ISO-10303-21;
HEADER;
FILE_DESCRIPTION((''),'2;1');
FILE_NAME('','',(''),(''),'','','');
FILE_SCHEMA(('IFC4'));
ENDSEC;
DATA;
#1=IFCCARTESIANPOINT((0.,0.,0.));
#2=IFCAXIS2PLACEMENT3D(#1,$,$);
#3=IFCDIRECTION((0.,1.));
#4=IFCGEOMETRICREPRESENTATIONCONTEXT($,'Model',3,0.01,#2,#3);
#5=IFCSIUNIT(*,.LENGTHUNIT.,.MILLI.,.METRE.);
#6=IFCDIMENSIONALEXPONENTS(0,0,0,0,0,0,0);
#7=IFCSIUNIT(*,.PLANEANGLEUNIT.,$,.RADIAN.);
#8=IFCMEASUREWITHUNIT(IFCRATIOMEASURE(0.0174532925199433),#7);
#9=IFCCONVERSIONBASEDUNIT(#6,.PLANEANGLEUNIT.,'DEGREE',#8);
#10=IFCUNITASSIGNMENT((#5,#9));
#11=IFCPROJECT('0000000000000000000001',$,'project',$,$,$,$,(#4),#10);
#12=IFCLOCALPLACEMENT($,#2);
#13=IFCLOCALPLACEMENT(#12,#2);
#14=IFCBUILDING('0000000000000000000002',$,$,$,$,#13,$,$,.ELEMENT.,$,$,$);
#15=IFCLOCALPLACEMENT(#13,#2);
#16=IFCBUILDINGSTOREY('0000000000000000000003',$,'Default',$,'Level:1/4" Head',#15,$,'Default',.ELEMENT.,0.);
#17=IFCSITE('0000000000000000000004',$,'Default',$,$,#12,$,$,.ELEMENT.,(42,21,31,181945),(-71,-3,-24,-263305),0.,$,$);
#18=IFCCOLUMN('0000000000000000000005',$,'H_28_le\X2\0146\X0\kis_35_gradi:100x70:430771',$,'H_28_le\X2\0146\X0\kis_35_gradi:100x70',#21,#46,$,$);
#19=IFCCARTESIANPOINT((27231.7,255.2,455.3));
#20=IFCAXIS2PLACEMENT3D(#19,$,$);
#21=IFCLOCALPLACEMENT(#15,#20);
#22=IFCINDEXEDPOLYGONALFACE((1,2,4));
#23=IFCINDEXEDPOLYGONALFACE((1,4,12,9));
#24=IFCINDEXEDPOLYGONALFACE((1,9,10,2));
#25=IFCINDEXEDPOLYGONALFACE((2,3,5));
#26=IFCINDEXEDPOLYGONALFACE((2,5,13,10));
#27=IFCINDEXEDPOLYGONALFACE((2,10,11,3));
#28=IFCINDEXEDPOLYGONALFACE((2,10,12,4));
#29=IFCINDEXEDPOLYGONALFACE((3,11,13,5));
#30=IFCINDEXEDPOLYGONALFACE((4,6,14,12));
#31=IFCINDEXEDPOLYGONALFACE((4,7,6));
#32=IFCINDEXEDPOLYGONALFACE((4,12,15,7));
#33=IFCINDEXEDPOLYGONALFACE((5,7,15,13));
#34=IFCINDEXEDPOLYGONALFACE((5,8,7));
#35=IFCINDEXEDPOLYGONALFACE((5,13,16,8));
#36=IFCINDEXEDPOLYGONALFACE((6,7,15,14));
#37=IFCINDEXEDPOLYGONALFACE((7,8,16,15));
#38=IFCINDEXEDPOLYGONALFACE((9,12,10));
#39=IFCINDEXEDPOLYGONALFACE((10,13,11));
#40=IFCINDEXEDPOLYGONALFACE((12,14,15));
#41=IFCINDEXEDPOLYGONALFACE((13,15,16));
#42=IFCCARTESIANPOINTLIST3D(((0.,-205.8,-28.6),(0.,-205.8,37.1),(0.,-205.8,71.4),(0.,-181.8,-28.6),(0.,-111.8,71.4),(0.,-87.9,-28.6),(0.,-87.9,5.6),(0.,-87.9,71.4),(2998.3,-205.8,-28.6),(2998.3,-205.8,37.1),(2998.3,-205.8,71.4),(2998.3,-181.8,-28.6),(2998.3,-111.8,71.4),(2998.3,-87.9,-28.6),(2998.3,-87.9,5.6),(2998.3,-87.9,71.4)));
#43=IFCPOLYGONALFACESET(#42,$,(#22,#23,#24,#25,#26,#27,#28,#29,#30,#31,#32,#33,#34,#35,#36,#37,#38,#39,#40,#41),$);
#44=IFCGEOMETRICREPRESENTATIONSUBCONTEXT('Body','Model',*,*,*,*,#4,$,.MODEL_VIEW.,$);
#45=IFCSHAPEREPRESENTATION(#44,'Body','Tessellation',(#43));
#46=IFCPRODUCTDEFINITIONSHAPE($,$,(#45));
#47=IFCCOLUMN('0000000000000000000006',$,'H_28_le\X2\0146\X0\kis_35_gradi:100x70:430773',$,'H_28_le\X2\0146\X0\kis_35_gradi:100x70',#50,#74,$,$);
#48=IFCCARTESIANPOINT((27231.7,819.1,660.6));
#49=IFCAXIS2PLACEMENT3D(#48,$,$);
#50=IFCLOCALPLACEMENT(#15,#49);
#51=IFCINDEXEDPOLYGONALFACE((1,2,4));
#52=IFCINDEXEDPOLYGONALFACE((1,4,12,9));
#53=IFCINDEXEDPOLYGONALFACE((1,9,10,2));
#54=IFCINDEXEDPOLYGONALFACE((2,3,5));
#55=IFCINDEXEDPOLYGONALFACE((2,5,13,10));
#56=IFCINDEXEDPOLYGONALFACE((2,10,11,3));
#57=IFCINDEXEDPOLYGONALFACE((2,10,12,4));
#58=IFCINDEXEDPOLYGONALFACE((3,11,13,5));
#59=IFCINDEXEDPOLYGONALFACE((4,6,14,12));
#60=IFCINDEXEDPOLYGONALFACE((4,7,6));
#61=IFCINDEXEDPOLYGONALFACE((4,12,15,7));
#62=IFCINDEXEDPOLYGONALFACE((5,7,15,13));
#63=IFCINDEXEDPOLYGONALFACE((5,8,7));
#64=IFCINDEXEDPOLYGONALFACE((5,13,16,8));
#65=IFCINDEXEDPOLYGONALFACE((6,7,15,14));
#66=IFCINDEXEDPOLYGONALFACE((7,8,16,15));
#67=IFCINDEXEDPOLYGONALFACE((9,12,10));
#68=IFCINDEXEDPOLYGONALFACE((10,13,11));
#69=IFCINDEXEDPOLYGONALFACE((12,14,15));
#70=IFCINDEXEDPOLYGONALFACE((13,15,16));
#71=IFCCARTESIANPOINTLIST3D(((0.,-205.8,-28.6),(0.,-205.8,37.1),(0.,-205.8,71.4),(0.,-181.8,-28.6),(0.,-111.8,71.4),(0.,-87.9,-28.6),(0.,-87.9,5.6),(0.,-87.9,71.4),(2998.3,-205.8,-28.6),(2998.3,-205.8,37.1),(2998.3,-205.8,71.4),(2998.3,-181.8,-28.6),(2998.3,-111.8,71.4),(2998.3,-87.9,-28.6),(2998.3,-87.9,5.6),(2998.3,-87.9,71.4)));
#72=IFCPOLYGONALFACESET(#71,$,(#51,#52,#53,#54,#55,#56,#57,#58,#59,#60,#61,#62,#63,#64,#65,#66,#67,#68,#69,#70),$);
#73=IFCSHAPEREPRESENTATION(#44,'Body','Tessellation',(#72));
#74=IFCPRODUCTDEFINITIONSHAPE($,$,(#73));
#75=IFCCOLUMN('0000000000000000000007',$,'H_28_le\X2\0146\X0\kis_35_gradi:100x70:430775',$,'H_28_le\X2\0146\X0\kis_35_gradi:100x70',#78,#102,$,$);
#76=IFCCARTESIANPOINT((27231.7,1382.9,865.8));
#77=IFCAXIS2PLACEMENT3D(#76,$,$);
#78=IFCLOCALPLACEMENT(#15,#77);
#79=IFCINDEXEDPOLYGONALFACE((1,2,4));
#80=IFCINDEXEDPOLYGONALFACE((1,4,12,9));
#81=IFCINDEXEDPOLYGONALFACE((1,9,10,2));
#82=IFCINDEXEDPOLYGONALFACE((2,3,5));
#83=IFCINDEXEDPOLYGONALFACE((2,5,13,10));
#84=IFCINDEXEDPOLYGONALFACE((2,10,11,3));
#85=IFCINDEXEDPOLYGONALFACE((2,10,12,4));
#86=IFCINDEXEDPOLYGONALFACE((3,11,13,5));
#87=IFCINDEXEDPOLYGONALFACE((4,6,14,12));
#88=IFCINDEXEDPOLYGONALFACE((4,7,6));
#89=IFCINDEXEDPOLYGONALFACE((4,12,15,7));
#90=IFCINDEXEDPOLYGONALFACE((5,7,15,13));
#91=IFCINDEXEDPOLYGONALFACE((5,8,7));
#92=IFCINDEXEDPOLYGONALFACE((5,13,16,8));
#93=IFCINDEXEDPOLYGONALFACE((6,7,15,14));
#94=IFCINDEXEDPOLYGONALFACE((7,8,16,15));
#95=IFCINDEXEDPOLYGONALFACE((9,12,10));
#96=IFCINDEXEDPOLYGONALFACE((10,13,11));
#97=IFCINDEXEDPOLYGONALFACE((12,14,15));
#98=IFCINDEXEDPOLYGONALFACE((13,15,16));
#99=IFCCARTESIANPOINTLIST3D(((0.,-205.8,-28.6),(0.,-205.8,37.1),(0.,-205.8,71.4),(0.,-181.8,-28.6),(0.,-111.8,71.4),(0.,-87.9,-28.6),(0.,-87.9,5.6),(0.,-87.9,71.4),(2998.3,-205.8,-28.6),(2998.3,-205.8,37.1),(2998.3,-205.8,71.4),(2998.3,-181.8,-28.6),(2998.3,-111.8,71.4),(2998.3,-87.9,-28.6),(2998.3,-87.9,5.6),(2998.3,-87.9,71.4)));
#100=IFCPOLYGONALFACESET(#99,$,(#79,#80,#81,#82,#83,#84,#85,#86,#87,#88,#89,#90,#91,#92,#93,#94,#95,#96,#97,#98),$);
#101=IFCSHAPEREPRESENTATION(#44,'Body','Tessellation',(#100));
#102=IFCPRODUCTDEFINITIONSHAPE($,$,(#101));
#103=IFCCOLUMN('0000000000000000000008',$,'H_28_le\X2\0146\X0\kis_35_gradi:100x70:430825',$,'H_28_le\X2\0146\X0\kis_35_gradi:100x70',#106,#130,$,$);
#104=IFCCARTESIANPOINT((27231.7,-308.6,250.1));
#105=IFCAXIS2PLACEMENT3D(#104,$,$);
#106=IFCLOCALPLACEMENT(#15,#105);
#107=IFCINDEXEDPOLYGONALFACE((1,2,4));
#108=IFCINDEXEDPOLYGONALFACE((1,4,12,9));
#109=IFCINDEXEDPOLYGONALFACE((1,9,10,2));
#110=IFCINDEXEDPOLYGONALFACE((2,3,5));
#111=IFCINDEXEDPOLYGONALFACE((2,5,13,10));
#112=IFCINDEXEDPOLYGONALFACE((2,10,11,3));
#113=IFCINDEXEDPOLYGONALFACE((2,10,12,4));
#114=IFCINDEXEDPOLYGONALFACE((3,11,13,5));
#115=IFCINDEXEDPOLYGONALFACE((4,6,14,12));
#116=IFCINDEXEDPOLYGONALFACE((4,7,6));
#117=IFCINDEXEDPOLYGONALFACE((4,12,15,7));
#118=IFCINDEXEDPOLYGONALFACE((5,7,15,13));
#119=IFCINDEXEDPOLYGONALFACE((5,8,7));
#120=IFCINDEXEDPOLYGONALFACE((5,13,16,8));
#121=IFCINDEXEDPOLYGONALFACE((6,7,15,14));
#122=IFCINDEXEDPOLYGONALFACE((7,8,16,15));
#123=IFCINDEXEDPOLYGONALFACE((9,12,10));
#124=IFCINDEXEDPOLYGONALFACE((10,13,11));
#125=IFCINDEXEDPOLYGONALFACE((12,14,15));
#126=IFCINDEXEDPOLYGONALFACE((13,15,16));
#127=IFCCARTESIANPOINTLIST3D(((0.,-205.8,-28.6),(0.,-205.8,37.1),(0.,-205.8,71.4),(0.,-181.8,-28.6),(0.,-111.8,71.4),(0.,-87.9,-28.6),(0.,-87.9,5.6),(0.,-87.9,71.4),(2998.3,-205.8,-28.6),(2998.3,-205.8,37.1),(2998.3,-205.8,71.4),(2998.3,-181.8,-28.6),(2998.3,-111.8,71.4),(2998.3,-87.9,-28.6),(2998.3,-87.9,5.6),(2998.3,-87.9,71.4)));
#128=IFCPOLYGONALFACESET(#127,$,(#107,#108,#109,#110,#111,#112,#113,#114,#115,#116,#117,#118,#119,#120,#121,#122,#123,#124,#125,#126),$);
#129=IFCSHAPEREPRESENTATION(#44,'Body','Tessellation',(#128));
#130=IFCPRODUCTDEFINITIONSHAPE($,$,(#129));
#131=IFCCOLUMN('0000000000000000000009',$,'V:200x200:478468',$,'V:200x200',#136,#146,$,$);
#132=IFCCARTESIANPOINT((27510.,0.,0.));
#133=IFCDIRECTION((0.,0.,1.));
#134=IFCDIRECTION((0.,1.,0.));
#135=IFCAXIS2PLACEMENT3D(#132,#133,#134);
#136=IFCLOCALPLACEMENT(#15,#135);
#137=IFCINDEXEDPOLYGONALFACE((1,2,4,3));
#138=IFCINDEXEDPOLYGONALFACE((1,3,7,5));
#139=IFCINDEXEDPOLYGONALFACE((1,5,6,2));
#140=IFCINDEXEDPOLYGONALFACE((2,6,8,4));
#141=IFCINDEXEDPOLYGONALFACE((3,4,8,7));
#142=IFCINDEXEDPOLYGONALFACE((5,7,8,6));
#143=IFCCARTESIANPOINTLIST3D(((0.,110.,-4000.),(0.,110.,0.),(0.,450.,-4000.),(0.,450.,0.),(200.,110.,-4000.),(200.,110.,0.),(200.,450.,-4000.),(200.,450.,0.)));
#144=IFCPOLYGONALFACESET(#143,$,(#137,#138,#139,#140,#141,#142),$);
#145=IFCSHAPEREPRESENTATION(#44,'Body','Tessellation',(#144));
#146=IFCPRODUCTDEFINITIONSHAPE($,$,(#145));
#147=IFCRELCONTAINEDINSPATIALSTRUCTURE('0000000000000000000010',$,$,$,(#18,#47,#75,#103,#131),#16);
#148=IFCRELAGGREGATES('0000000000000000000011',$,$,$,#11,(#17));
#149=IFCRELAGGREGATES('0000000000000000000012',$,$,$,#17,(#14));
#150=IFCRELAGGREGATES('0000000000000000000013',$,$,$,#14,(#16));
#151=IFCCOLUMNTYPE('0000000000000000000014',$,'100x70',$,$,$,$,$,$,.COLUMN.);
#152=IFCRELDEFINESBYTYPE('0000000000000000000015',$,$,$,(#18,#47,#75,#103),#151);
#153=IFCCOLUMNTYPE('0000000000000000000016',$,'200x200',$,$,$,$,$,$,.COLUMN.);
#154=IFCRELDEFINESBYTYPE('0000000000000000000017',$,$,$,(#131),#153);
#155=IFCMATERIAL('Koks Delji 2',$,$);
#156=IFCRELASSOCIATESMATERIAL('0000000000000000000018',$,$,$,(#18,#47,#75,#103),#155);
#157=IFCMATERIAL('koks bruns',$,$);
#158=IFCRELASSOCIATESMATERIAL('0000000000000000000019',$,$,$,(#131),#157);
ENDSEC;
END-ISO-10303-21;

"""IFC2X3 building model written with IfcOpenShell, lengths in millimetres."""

from ifc_helpers import new_model, entity, si_unit, converted_unit, direction, frame, frame_2d, origin, origin_2d_with_axis, place, context, subcontext, project, spatial, rectangle, extrude, boolean, source, transform, mapped, material, type_object, type_shapes, element, save


model = new_model("IFC2X3")

# Units and contexts
model_context = context("Model", 3, precision=0.01, world=origin(), true_north=direction((0.0, 1.0)))
body_context = subcontext(model_context, "Body", "Model", "MODEL_VIEW")
ifc_project = project(units=[si_unit("LENGTHUNIT", "METRE", prefix="MILLI"), converted_unit("PLANEANGLEUNIT", "DEGREE", entity("IfcRatioMeasure", 0.0174532925199433), si_unit("PLANEANGLEUNIT", "RADIAN"), dimensions=[0, 0, 0, 0, 0, 0, 0])], contexts=[model_context])

# Site, building, storey
site_placement = place(None, origin())
site = spatial("IfcSite", under=ifc_project, at=site_placement, Name="Default", CompositionType="ELEMENT", RefLatitude=(42, 21, 31, 181945), RefLongitude=(-71, -3, -24, -263305), RefElevation=0.0)
building_placement = place(site_placement, origin())
building = spatial("IfcBuilding", under=site, at=building_placement, CompositionType="ELEMENT")
storey_placement = place(building_placement, origin())
storey = spatial("IfcBuildingStorey", under=building, at=storey_placement, Name="Default", ObjectType="Level:1/4\" Head", LongName="Default", CompositionType="ELEMENT", Elevation=0.0)

# Columns
ifc_material_1 = material(Name="Koks Delji 2")
column_type_1 = type_object("IfcColumnType", Name="100x70", PredefinedType="COLUMN")
shared_shape_1 = source(origin(), body_context, "Body", "CSG", [
    boolean("DIFFERENCE", extrude(rectangle(XDim=2998.3, YDim=117.9, at=frame_2d((0.0, 0.0), x_axis=(1.0, 0.0))), frame((1499.1, -146.8, -28.6)), (0.0, 0.0, 1.0), 100.0), extrude(rectangle(XDim=70.0, YDim=100.0, at=frame_2d((0.0, 0.0), x_axis=(0.0, 1.0))), frame((0.0, -146.8, 21.4), z_axis=(-1.0, 0.0, 0.0), x_axis=(0.0, -0.939693, -0.34202)), (0.0, 0.0, -1.0), 2998.3)),
])
type_shapes(column_type_1, [shared_shape_1])
for number, where, name in (
    (1, (27231.7, 255.2, 455.3), "H_28_leņkis_35_gradi:100x70:430771"),
    (2, (27231.7, 819.1, 660.6), "H_28_leņkis_35_gradi:100x70:430773"),
    (3, (27231.7, 1382.9, 865.8), "H_28_leņkis_35_gradi:100x70:430775"),
    (4, (27231.7, -308.6, 250.1), "H_28_leņkis_35_gradi:100x70:430825"),
):
    element("IfcColumn", number, at=place(storey_placement, frame(where)), inside=storey, type_object=column_type_1, material=ifc_material_1, Name=name, ObjectType="H_28_leņkis_35_gradi:100x70", context=body_context, shape_type="MappedRepresentation", body=[
        mapped(shared_shape_1, transform((0.0, 0.0, 0.0), scale=1.0)),
    ])
ifc_material_2 = material(Name="koks bruns")
column_type_2 = type_object("IfcColumnType", Name="200x200", PredefinedType="COLUMN")
shared_shape_2 = source(origin(), body_context, "Body", "SweptSolid", [
    extrude(rectangle(XDim=340.0, YDim=200.0, at=origin_2d_with_axis()), frame((100.0, 280.0, -4000.0), z_axis=(0.0, 0.0, 1.0), x_axis=(0.0, -1.0, 0.0)), (0.0, 0.0, 1.0), 4000.0),
])
type_shapes(column_type_2, [shared_shape_2])
column_placement = place(storey_placement, frame((27510.0, 0.0, 0.0), z_axis=(0.0, 0.0, 1.0), x_axis=(0.0, 1.0, 0.0)))
element("IfcColumn", 5, at=column_placement, inside=storey, type_object=column_type_2, material=ifc_material_2, Name="V:200x200:478468", ObjectType="V:200x200", context=body_context, shape_type="MappedRepresentation", body=[
    mapped(shared_shape_2, transform((0.0, 0.0, 0.0), scale=1.0)),
])

save(model, "model.ifc")
